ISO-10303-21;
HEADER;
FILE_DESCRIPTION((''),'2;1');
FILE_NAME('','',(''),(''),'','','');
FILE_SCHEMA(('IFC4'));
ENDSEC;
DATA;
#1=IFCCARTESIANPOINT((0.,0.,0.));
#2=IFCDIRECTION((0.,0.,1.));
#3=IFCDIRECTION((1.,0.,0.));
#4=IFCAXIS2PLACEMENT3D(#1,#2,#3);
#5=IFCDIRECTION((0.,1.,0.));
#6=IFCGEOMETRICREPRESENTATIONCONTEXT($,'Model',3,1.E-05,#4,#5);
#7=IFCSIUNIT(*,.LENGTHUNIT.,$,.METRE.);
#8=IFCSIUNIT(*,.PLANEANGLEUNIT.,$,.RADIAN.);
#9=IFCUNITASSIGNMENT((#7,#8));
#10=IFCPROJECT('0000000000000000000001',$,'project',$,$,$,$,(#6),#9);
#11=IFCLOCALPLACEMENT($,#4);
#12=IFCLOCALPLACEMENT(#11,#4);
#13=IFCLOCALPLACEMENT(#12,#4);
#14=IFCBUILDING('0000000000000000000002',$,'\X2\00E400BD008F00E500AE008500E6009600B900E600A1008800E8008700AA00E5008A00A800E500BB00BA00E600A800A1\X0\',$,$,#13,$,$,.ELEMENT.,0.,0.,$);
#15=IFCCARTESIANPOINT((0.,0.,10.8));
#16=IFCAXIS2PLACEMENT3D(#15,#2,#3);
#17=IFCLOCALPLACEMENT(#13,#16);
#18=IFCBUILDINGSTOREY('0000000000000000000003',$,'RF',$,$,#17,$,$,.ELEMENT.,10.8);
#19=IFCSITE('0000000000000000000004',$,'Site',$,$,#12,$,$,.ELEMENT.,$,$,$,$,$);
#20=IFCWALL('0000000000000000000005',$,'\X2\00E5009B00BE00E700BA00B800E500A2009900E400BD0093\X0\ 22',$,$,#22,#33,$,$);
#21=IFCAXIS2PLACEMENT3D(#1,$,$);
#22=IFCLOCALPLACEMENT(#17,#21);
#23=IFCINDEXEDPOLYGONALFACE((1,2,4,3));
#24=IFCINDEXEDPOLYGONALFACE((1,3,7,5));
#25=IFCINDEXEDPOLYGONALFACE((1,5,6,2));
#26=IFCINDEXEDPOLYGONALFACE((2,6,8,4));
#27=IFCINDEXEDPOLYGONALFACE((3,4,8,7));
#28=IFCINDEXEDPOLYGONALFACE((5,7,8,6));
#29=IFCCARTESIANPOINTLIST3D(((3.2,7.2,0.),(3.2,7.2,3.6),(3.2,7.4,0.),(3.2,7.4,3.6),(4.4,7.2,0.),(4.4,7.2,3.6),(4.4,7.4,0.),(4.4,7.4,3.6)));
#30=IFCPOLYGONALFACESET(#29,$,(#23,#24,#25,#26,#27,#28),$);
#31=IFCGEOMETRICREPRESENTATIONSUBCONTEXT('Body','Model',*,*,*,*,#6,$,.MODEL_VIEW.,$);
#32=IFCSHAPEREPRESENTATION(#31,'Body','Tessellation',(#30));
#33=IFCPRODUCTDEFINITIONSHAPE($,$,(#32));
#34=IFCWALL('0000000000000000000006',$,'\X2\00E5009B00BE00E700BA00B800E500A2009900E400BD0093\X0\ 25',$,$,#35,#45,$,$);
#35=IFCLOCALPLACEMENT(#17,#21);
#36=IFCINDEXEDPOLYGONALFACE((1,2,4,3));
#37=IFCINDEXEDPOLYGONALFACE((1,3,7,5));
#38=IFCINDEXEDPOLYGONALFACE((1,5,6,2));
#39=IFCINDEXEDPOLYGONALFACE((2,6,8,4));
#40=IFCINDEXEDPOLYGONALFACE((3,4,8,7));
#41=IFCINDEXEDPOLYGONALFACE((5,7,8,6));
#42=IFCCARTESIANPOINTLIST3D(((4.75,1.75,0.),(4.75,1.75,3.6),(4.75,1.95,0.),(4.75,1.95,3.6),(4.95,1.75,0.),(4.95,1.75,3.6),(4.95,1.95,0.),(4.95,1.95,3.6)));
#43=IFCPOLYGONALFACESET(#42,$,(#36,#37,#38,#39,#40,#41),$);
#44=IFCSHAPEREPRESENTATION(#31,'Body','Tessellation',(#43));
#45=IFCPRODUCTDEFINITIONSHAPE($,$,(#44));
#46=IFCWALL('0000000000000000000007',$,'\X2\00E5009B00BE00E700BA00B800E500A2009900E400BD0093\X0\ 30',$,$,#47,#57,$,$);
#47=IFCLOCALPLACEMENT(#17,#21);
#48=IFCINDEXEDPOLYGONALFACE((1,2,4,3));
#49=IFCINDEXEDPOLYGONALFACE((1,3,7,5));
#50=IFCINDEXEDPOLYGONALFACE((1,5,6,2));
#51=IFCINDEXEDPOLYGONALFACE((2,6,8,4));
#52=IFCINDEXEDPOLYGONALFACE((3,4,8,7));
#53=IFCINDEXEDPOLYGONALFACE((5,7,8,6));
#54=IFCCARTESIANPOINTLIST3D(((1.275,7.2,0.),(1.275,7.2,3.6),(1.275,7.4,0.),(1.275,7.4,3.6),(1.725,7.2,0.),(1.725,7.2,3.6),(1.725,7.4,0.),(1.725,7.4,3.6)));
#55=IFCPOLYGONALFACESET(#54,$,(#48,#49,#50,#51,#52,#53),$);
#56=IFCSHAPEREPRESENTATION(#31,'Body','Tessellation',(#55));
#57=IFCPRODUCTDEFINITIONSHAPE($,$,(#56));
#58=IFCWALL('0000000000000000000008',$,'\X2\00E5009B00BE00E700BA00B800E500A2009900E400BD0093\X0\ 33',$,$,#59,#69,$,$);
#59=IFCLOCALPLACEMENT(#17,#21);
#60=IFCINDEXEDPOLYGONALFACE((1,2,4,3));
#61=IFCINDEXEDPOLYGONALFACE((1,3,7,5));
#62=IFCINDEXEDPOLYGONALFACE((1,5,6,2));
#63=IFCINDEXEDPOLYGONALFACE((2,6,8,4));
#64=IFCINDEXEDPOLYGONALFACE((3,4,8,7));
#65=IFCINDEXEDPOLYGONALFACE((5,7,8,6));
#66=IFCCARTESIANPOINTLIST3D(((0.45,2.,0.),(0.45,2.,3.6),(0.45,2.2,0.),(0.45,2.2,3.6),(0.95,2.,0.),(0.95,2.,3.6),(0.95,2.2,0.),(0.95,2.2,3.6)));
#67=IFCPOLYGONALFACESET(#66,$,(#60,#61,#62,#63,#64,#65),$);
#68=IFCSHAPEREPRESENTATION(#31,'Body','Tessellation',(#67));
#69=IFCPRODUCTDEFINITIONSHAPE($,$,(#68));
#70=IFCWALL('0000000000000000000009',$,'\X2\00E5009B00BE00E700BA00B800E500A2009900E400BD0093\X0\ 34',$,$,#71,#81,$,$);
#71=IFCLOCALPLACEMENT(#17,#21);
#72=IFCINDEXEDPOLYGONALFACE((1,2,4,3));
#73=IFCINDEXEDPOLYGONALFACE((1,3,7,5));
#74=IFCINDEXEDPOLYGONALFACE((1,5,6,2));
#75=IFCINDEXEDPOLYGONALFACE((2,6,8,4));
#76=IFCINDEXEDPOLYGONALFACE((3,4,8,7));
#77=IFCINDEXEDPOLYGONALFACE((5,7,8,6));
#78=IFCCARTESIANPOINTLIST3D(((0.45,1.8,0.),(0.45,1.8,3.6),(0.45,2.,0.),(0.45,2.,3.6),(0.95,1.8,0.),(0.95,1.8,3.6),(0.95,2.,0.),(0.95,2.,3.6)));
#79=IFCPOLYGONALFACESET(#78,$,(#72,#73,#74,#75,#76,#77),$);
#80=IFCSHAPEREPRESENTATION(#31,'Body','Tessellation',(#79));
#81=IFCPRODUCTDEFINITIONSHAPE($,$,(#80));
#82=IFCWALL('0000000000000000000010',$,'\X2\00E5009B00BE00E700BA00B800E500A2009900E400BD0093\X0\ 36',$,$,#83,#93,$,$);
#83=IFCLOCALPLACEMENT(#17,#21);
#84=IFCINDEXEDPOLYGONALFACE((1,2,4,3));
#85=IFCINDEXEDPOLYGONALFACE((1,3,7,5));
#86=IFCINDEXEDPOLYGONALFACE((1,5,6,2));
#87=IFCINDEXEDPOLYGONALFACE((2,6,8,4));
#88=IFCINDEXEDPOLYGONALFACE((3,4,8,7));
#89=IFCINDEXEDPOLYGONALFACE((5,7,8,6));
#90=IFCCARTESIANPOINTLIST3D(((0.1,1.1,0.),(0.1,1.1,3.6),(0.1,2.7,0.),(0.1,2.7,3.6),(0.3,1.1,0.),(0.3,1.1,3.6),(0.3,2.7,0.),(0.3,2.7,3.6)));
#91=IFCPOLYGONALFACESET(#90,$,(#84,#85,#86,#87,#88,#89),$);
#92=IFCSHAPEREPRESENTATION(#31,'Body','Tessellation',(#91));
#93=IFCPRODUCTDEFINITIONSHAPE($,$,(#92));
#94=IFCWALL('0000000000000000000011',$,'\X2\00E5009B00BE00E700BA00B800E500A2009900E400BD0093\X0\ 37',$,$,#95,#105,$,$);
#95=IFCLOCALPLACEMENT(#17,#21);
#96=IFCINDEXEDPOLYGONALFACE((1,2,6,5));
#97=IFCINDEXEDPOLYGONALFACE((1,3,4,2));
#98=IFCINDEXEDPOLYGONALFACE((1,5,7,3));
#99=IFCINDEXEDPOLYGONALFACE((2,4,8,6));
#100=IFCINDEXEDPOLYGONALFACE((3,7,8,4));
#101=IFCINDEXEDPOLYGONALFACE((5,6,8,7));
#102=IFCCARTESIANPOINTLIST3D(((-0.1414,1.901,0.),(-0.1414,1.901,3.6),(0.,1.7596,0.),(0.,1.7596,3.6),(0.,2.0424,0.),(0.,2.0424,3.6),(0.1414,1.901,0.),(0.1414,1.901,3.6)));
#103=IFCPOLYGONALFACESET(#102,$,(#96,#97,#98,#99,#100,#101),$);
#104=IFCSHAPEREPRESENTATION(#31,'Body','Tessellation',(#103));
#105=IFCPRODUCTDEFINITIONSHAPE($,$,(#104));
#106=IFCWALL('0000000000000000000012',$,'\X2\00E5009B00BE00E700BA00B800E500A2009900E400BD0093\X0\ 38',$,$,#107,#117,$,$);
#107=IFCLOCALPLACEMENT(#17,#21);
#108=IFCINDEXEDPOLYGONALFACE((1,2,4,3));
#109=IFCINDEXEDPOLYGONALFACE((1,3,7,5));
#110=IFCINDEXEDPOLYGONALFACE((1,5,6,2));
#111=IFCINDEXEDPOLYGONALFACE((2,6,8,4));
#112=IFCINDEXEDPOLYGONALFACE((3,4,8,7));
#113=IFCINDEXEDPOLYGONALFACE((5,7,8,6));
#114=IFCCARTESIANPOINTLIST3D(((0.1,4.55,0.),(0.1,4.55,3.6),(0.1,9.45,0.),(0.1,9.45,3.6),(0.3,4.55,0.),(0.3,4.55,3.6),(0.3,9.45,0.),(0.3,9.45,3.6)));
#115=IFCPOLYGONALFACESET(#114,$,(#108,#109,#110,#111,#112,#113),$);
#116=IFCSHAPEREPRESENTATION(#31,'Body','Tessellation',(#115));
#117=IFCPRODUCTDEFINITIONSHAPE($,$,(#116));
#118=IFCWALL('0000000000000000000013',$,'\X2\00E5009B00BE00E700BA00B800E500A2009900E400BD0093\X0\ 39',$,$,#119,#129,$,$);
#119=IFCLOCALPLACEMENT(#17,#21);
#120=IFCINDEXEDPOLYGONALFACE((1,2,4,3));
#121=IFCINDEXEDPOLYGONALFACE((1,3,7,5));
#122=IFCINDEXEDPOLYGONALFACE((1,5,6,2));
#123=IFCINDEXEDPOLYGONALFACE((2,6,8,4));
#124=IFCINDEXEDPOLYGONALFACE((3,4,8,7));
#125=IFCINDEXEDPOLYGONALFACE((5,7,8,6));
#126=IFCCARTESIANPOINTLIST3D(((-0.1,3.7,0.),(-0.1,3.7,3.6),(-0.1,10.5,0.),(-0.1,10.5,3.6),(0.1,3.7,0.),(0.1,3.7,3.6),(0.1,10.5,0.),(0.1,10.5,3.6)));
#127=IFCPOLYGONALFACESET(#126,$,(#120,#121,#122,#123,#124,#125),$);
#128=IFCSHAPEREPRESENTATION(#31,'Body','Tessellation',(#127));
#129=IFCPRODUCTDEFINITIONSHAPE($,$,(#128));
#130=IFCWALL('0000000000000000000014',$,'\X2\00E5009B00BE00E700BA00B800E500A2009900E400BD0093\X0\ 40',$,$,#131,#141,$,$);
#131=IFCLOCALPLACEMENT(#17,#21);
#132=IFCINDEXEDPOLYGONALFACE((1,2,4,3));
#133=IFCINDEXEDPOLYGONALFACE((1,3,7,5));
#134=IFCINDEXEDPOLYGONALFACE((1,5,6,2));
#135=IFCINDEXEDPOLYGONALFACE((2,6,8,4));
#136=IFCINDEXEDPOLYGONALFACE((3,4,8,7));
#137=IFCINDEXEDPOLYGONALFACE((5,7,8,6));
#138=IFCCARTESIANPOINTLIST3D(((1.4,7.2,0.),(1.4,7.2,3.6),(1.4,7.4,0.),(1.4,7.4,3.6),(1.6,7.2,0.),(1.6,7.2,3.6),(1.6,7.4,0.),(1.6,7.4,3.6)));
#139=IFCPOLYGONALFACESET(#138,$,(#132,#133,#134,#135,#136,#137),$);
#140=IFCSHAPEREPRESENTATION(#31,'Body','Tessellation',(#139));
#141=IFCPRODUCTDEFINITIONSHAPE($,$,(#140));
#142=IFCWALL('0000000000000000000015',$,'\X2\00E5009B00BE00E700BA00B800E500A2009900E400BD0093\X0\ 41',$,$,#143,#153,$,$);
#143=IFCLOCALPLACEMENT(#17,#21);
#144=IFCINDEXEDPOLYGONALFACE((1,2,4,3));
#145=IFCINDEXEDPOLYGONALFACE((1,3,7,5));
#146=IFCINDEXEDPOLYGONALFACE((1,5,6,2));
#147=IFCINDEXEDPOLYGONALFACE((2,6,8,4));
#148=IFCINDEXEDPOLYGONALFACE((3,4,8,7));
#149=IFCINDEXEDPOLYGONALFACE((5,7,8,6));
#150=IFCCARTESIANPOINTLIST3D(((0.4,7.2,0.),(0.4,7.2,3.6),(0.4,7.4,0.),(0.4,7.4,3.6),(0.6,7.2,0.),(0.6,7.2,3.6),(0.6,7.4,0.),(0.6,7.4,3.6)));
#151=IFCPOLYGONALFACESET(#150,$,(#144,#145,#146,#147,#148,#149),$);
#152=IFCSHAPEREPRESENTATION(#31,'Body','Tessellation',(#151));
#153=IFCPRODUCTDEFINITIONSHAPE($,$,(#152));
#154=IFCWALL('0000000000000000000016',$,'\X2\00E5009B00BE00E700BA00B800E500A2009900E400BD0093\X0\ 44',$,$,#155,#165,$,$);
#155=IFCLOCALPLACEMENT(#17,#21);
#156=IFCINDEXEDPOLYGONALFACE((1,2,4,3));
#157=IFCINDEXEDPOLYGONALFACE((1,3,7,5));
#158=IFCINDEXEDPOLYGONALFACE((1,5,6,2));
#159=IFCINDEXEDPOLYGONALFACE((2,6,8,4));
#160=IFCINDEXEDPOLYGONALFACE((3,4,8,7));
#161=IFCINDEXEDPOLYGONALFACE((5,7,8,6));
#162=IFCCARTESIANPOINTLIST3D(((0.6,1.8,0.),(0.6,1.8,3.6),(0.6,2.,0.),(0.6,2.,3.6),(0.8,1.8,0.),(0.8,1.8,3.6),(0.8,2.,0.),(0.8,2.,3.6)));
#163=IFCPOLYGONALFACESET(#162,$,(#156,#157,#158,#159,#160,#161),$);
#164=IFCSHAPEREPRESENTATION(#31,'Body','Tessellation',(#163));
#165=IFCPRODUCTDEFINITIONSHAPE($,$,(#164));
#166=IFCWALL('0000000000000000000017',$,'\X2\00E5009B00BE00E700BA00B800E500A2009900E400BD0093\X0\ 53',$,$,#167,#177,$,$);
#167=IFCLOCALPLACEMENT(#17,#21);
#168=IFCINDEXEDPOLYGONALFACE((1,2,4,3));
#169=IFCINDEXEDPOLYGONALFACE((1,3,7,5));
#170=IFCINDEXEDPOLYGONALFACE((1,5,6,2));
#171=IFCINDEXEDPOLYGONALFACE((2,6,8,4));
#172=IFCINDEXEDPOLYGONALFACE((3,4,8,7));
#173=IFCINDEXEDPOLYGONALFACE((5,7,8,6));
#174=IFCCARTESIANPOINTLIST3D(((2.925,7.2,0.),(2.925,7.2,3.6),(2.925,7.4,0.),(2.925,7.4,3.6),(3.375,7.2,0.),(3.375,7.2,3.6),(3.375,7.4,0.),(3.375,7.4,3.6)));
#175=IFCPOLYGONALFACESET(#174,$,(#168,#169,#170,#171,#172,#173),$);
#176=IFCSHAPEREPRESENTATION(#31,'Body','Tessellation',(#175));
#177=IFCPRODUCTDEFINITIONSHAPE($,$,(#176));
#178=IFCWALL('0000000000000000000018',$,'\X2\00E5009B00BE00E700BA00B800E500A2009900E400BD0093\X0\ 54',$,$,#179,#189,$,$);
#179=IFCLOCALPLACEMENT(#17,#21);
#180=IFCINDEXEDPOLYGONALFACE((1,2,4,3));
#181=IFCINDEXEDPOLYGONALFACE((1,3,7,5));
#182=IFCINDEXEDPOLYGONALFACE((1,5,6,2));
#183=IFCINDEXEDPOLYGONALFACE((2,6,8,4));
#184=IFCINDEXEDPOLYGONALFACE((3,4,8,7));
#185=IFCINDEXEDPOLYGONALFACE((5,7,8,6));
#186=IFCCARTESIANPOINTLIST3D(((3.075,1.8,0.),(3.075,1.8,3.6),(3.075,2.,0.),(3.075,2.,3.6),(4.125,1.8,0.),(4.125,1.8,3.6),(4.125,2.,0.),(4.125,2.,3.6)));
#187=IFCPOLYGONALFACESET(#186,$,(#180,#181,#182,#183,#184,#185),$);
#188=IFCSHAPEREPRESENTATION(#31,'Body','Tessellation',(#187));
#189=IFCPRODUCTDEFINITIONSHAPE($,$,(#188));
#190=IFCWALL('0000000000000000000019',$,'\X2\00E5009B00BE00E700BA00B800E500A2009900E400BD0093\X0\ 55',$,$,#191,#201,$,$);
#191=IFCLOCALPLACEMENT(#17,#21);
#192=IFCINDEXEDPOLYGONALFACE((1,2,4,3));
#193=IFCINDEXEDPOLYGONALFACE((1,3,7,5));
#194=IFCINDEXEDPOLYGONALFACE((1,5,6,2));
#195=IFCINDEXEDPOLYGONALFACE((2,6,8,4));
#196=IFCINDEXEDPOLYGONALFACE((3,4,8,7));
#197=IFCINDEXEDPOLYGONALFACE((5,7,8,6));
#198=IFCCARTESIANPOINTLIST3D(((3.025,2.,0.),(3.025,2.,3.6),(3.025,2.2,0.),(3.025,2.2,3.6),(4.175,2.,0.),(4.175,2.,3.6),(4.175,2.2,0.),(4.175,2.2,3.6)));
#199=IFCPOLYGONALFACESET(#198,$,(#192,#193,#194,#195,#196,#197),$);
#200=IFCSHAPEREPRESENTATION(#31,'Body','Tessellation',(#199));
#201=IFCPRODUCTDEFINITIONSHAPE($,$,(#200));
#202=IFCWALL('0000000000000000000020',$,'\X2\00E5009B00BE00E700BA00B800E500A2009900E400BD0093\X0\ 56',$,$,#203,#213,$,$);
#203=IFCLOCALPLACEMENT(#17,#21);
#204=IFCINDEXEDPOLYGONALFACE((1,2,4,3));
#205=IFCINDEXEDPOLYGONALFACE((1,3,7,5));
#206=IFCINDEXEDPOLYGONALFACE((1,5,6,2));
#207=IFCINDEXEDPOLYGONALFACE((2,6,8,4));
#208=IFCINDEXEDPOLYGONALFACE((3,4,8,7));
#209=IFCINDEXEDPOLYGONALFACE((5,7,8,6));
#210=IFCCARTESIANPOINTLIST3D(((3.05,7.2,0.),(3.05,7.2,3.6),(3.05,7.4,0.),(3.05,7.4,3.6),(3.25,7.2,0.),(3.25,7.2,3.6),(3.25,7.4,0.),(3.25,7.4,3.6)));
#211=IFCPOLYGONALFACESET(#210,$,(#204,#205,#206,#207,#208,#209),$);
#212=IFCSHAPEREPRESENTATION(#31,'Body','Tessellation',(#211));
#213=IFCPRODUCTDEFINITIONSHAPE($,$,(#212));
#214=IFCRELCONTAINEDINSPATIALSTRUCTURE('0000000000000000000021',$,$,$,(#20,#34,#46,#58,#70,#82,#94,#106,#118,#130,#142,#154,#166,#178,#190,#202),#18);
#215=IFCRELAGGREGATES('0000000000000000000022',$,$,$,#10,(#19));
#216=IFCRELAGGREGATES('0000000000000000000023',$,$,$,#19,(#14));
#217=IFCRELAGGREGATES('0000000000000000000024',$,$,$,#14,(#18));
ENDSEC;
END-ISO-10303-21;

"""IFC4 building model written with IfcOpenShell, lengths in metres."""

from ifc_helpers import new_model, si_unit, direction, frame, frame_2d, origin_with_axes, place, context, subcontext, project, spatial, rectangle, extrude, element, save


model = new_model("IFC4")

# Units and contexts
model_context = context("Model", 3, precision=1e-05, world=origin_with_axes(), true_north=direction((0.0, 1.0, 0.0)))
body_context = subcontext(model_context, "Body", "Model", "MODEL_VIEW")
ifc_project = project(units=[si_unit("LENGTHUNIT", "METRE"), si_unit("PLANEANGLEUNIT", "RADIAN")], contexts=[model_context])

# Site, building, storey
placement = place(None, origin_with_axes())
site_placement = place(placement, origin_with_axes())
site = spatial("IfcSite", under=ifc_project, at=site_placement, Name="Site", CompositionType="ELEMENT")
building_placement = place(site_placement, origin_with_axes())
building = spatial("IfcBuilding", under=site, at=building_placement, Name="ä½\u008få®\u0085æ\u0096¹æ¡\u0088è\u0087ªå\u008a¨å»ºæ¨¡", CompositionType="ELEMENT", ElevationOfRefHeight=0.0, ElevationOfTerrain=0.0)
storey_placement = place(building_placement, frame((0.0, 0.0, 10.8), z_axis=(0.0, 0.0, 1.0), x_axis=(1.0, 0.0, 0.0)))
storey = spatial("IfcBuildingStorey", under=building, at=storey_placement, Name="RF", CompositionType="ELEMENT", Elevation=10.8)

# Walls
wall_1_placement = place(storey_placement, frame((3.8, 7.3, 0.0), z_axis=(0.0, 0.0, 1.0), x_axis=(1.0, 0.0, 0.0)))
element("IfcWall", 1, at=wall_1_placement, inside=storey, Name="å\u009b¾çº¸å¢\u0099ä½\u0093 22", context=body_context, shape_type="SweptSolid", body=[
    extrude(rectangle(XDim=1.2, YDim=0.2, at=frame_2d((0.0, 0.0), x_axis=(1.0, 0.0, 0.0))), frame((0.0, 0.0, 0.0), z_axis=(0.0, 0.0, 1.0)), (0.0, 0.0, 1.0), 3.6),
])
wall_2_placement = place(storey_placement, frame((4.85, 1.85, 0.0), z_axis=(0.0, 0.0, 1.0), x_axis=(1.0, 0.0, 0.0)))
element("IfcWall", 2, at=wall_2_placement, inside=storey, Name="å\u009b¾çº¸å¢\u0099ä½\u0093 25", context=body_context, shape_type="SweptSolid", body=[
    extrude(rectangle(XDim=0.2, YDim=0.2, at=frame_2d((0.0, 0.0), x_axis=(1.0, 0.0, 0.0))), frame((0.0, 0.0, 0.0), z_axis=(0.0, 0.0, 1.0)), (0.0, 0.0, 1.0), 3.6),
])
wall_3_placement = place(storey_placement, frame((1.5, 7.3, 0.0), z_axis=(0.0, 0.0, 1.0), x_axis=(1.0, 0.0, 0.0)))
element("IfcWall", 3, at=wall_3_placement, inside=storey, Name="å\u009b¾çº¸å¢\u0099ä½\u0093 30", context=body_context, shape_type="SweptSolid", body=[
    extrude(rectangle(XDim=0.45, YDim=0.2, at=frame_2d((0.0, 0.0), x_axis=(1.0, 0.0, 0.0))), frame((0.0, 0.0, 0.0), z_axis=(0.0, 0.0, 1.0)), (0.0, 0.0, 1.0), 3.6),
])
for number, where, z_axis, x_axis, name in (
    (4, (0.7, 2.1, 0.0), (0.0, 0.0, 1.0), (-1.0, 0.0, 0.0), "å\u009b¾çº¸å¢\u0099ä½\u0093 33"),
    (5, (0.7, 1.9, 0.0), (0.0, 0.0, 1.0), (-1.0, 0.0, 0.0), "å\u009b¾çº¸å¢\u0099ä½\u0093 34"),
):
    element("IfcWall", number, at=place(storey_placement, frame(where, z_axis=z_axis, x_axis=x_axis)), inside=storey, Name=name, context=body_context, shape_type="SweptSolid", body=[
        extrude(rectangle(XDim=0.5, YDim=0.2, at=frame_2d((0.0, 0.0), x_axis=(1.0, 0.0, 0.0))), frame((0.0, 0.0, 0.0), z_axis=(0.0, 0.0, 1.0)), (0.0, 0.0, 1.0), 3.6),
    ])
wall_4_placement = place(storey_placement, frame((0.2, 1.9, 0.0), z_axis=(0.0, 0.0, 1.0), x_axis=(0.0, -1.0, 0.0)))
element("IfcWall", 6, at=wall_4_placement, inside=storey, Name="å\u009b¾çº¸å¢\u0099ä½\u0093 36", context=body_context, shape_type="SweptSolid", body=[
    extrude(rectangle(XDim=1.6, YDim=0.2, at=frame_2d((0.0, 0.0), x_axis=(1.0, 0.0, 0.0))), frame((0.0, 0.0, 0.0), z_axis=(0.0, 0.0, 1.0)), (0.0, 0.0, 1.0), 3.6),
])
wall_5_placement = place(storey_placement, frame((0.0, 1.901, 0.0), z_axis=(0.0, 0.0, 1.0), x_axis=(0.707107, -0.707107, 0.0)))
element("IfcWall", 7, at=wall_5_placement, inside=storey, Name="å\u009b¾çº¸å¢\u0099ä½\u0093 37", context=body_context, shape_type="SweptSolid", body=[
    extrude(rectangle(XDim=0.2, YDim=0.2, at=frame_2d((0.0, 0.0), x_axis=(1.0, 0.0, 0.0))), frame((0.0, 0.0, 0.0), z_axis=(0.0, 0.0, 1.0)), (0.0, 0.0, 1.0), 3.6),
])
wall_6_placement = place(storey_placement, frame((0.2, 7.0, 0.0), z_axis=(0.0, 0.0, 1.0), x_axis=(0.0, -1.0, 0.0)))
element("IfcWall", 8, at=wall_6_placement, inside=storey, Name="å\u009b¾çº¸å¢\u0099ä½\u0093 38", context=body_context, shape_type="SweptSolid", body=[
    extrude(rectangle(XDim=4.9, YDim=0.2, at=frame_2d((0.0, 0.0), x_axis=(1.0, 0.0, 0.0))), frame((0.0, 0.0, 0.0), z_axis=(0.0, 0.0, 1.0)), (0.0, 0.0, 1.0), 3.6),
])
wall_7_placement = place(storey_placement, frame((0.0, 7.1, 0.0), z_axis=(0.0, 0.0, 1.0), x_axis=(0.0, -1.0, 0.0)))
element("IfcWall", 9, at=wall_7_placement, inside=storey, Name="å\u009b¾çº¸å¢\u0099ä½\u0093 39", context=body_context, shape_type="SweptSolid", body=[
    extrude(rectangle(XDim=6.8, YDim=0.2, at=frame_2d((0.0, 0.0), x_axis=(1.0, 0.0, 0.0))), frame((0.0, 0.0, 0.0), z_axis=(0.0, 0.0, 1.0)), (0.0, 0.0, 1.0), 3.6),
])
for number, where, z_axis, x_axis, name in (
    (10, (1.5, 7.3, 0.0), (0.0, 0.0, 1.0), (0.0, 1.0, 0.0), "å\u009b¾çº¸å¢\u0099ä½\u0093 40"),
    (11, (0.5, 7.3, 0.0), (0.0, 0.0, 1.0), (0.0, 1.0, 0.0), "å\u009b¾çº¸å¢\u0099ä½\u0093 41"),
    (12, (0.7, 1.9, 0.0), (0.0, 0.0, 1.0), (0.0, 1.0, 0.0), "å\u009b¾çº¸å¢\u0099ä½\u0093 44"),
):
    element("IfcWall", number, at=place(storey_placement, frame(where, z_axis=z_axis, x_axis=x_axis)), inside=storey, Name=name, context=body_context, shape_type="SweptSolid", body=[
        extrude(rectangle(XDim=0.2, YDim=0.2, at=frame_2d((0.0, 0.0), x_axis=(1.0, 0.0, 0.0))), frame((0.0, 0.0, 0.0), z_axis=(0.0, 0.0, 1.0)), (0.0, 0.0, 1.0), 3.6),
    ])
wall_8_placement = place(storey_placement, frame((3.15, 7.3, 0.0), z_axis=(0.0, 0.0, 1.0), x_axis=(1.0, 0.0, 0.0)))
element("IfcWall", 13, at=wall_8_placement, inside=storey, Name="å\u009b¾çº¸å¢\u0099ä½\u0093 53", context=body_context, shape_type="SweptSolid", body=[
    extrude(rectangle(XDim=0.45, YDim=0.2, at=frame_2d((0.0, 0.0), x_axis=(1.0, 0.0, 0.0))), frame((0.0, 0.0, 0.0), z_axis=(0.0, 0.0, 1.0)), (0.0, 0.0, 1.0), 3.6),
])
wall_9_placement = place(storey_placement, frame((3.6, 1.9, 0.0), z_axis=(0.0, 0.0, 1.0), x_axis=(-1.0, 0.0, 0.0)))
element("IfcWall", 14, at=wall_9_placement, inside=storey, Name="å\u009b¾çº¸å¢\u0099ä½\u0093 54", context=body_context, shape_type="SweptSolid", body=[
    extrude(rectangle(XDim=1.05, YDim=0.2, at=frame_2d((0.0, 0.0), x_axis=(1.0, 0.0, 0.0))), frame((0.0, 0.0, 0.0), z_axis=(0.0, 0.0, 1.0)), (0.0, 0.0, 1.0), 3.6),
])
wall_10_placement = place(storey_placement, frame((3.6, 2.1, 0.0), z_axis=(0.0, 0.0, 1.0), x_axis=(-1.0, 0.0, 0.0)))
element("IfcWall", 15, at=wall_10_placement, inside=storey, Name="å\u009b¾çº¸å¢\u0099ä½\u0093 55", context=body_context, shape_type="SweptSolid", body=[
    extrude(rectangle(XDim=1.15, YDim=0.2, at=frame_2d((0.0, 0.0), x_axis=(1.0, 0.0, 0.0))), frame((0.0, 0.0, 0.0), z_axis=(0.0, 0.0, 1.0)), (0.0, 0.0, 1.0), 3.6),
])
for number, where, z_axis, x_axis, name in (
    (16, (3.15, 7.3, 0.0), (0.0, 0.0, 1.0), (0.0, 1.0, 0.0), "å\u009b¾çº¸å¢\u0099ä½\u0093 56"),
):
    element("IfcWall", number, at=place(storey_placement, frame(where, z_axis=z_axis, x_axis=x_axis)), inside=storey, Name=name, context=body_context, shape_type="SweptSolid", body=[
        extrude(rectangle(XDim=0.2, YDim=0.2, at=frame_2d((0.0, 0.0), x_axis=(1.0, 0.0, 0.0))), frame((0.0, 0.0, 0.0), z_axis=(0.0, 0.0, 1.0)), (0.0, 0.0, 1.0), 3.6),
    ])

save(model, "model.ifc")
